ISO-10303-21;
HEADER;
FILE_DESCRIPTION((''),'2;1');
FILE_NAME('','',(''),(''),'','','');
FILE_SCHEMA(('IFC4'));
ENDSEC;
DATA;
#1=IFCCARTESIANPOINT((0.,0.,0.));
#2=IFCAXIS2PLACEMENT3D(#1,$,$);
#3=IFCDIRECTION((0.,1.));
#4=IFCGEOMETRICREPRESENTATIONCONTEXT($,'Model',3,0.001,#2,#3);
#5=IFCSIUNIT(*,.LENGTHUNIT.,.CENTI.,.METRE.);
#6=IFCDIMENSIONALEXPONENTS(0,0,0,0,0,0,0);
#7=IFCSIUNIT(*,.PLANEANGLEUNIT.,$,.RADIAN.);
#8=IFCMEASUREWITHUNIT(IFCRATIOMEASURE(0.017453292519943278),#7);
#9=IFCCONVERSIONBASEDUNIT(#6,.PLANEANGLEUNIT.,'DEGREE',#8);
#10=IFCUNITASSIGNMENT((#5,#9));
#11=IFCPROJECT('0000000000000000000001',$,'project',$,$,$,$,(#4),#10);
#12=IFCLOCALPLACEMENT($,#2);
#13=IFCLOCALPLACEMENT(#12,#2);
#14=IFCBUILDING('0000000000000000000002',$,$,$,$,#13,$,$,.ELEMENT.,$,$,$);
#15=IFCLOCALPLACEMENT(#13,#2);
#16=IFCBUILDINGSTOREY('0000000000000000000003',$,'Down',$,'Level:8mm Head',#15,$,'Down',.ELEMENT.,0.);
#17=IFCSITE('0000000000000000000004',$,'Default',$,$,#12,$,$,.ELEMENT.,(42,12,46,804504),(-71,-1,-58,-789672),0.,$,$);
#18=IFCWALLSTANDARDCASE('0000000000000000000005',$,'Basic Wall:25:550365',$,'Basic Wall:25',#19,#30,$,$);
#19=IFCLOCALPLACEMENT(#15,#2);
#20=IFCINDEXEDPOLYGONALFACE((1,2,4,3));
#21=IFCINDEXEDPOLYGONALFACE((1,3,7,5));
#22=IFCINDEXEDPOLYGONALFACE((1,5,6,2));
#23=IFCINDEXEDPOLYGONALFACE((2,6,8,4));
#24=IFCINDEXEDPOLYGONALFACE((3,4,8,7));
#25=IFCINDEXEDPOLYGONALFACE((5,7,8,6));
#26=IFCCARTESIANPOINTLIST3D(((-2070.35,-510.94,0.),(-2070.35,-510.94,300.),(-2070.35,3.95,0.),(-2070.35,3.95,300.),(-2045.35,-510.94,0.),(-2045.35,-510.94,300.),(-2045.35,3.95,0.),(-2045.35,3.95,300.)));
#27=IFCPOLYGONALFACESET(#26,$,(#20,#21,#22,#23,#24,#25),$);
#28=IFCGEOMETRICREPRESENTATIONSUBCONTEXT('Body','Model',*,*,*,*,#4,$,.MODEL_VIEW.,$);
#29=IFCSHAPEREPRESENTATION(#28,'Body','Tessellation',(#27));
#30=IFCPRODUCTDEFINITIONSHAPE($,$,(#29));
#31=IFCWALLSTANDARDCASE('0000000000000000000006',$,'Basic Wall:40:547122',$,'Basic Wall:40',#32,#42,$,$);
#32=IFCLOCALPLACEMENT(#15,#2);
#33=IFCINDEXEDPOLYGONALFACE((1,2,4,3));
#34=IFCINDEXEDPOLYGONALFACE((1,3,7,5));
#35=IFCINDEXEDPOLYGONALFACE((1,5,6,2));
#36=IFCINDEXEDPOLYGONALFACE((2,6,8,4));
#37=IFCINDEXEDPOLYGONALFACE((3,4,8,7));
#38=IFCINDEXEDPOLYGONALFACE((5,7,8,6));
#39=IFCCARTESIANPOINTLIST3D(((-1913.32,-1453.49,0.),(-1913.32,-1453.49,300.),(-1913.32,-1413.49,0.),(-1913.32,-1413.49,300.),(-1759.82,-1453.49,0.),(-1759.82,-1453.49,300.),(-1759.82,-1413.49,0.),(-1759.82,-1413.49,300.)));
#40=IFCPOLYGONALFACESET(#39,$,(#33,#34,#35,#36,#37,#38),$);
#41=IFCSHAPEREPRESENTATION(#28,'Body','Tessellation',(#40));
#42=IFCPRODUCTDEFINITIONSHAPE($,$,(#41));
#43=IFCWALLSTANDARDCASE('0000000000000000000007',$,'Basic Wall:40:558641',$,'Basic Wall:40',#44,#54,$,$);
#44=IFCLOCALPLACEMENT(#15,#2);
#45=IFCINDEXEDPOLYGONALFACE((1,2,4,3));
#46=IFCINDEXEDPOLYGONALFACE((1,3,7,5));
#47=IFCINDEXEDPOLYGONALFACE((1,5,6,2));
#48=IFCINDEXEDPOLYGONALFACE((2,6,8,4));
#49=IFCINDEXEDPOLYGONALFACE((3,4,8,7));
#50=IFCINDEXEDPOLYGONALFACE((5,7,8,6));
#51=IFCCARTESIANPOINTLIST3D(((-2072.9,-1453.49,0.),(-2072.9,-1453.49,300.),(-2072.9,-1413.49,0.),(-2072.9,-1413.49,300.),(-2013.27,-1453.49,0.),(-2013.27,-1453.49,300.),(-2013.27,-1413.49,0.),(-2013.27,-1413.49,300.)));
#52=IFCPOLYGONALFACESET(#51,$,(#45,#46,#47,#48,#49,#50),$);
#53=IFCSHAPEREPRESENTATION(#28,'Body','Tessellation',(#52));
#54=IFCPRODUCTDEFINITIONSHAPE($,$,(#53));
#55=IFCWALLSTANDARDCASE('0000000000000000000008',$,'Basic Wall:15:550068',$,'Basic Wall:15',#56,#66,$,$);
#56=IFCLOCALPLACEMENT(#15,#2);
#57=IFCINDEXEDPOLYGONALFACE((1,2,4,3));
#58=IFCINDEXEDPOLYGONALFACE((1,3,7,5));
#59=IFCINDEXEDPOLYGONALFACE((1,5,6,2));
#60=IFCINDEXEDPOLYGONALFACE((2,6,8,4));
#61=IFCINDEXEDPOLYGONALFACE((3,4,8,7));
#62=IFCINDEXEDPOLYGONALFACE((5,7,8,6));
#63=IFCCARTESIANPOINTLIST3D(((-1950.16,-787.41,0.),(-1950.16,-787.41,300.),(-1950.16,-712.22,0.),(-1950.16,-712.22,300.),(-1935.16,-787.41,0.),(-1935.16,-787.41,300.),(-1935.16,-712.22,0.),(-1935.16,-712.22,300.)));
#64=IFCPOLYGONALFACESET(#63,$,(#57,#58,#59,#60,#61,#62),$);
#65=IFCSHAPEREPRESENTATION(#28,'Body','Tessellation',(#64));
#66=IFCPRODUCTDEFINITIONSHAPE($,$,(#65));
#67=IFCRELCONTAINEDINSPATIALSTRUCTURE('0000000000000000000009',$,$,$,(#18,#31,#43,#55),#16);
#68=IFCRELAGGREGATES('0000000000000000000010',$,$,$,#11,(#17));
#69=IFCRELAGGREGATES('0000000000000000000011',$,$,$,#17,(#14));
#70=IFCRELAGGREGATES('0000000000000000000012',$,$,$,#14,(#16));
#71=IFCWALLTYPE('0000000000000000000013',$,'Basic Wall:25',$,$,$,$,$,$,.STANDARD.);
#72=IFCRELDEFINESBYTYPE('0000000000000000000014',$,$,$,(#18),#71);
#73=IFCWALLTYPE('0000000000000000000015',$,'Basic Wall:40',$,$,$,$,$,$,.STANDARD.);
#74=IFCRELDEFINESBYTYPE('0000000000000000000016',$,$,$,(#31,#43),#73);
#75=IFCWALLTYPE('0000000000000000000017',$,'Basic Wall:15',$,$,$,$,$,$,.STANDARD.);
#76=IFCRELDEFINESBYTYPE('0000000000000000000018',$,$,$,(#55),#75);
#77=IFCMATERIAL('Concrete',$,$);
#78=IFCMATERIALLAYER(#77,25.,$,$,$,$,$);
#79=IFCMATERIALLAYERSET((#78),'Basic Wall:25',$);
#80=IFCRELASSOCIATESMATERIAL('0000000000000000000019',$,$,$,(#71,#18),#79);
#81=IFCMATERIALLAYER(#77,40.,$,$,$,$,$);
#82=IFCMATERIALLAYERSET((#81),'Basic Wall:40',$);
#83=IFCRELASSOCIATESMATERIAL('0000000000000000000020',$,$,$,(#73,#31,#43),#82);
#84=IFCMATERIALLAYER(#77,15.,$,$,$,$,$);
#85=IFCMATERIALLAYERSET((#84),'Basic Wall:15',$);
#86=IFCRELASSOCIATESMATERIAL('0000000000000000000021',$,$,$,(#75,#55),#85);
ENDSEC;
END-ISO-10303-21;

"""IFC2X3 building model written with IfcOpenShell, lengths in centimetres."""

from ifc_helpers import new_model, entity, si_unit, converted_unit, direction, frame, frame_2d, origin, place, context, subcontext, project, spatial, rectangle, extrude, material, layer, layer_set, layer_usage, type_object, element, save


model = new_model("IFC2X3")

# Units and contexts
model_context = context("Model", 3, precision=0.001, world=origin(), true_north=direction((0.0, 1.0)))
body_context = subcontext(model_context, "Body", "Model", "MODEL_VIEW")
ifc_project = project(units=[si_unit("LENGTHUNIT", "METRE", prefix="CENTI"), converted_unit("PLANEANGLEUNIT", "DEGREE", entity("IfcRatioMeasure", 0.017453292519943278), si_unit("PLANEANGLEUNIT", "RADIAN"), dimensions=[0, 0, 0, 0, 0, 0, 0])], contexts=[model_context])

# Site, building, storey
site_placement = place(None, origin())
site = spatial("IfcSite", under=ifc_project, at=site_placement, Name="Default", CompositionType="ELEMENT", RefLatitude=(42, 12, 46, 804504), RefLongitude=(-71, -1, -58, -789672), RefElevation=0.0)
building_placement = place(site_placement, origin())
building = spatial("IfcBuilding", under=site, at=building_placement, CompositionType="ELEMENT")
storey_placement = place(building_placement, origin())
storey = spatial("IfcBuildingStorey", under=building, at=storey_placement, Name="Down", ObjectType="Level:8mm Head", LongName="Down", CompositionType="ELEMENT", Elevation=0.0)

# Walls
ifc_material = material(Name="Concrete")
ifc_layer_1 = layer(ifc_material, 25.0)
ifc_layer_set_1 = layer_set([ifc_layer_1], Name="Basic Wall:25")
wall_type_1 = type_object("IfcWallType", Name="Basic Wall:25", PredefinedType="STANDARD", material=ifc_layer_set_1)
ifc_layer_usage_1 = layer_usage(ifc_layer_set_1, "AXIS2", "NEGATIVE", 12.5)
wall_1_placement = place(storey_placement, frame((-2057.85, -510.94, 0.0), z_axis=(0.0, 0.0, 1.0), x_axis=(0.0, 1.0, 0.0)))
element("IfcWallStandardCase", 1, at=wall_1_placement, inside=storey, type_object=wall_type_1, material=ifc_layer_usage_1, Name="Basic Wall:25:550365", ObjectType="Basic Wall:25", context=body_context, shape_type="SweptSolid", body=[
    extrude(rectangle(XDim=514.89, YDim=25.0, at=frame_2d((257.44, 0.0), x_axis=(-1.0, 0.0))), origin(), (0.0, 0.0, 1.0), 300.0),
])
ifc_layer_2 = layer(ifc_material, 40.0)
ifc_layer_set_2 = layer_set([ifc_layer_2], Name="Basic Wall:40")
ifc_layer_usage_2 = layer_usage(ifc_layer_set_2, "AXIS2", "POSITIVE", -20.0)
wall_type_2 = type_object("IfcWallType", Name="Basic Wall:40", PredefinedType="STANDARD", material=ifc_layer_set_2)
wall_2_placement = place(storey_placement, frame((-1913.32, -1433.49, 0.0)))
element("IfcWallStandardCase", 2, at=wall_2_placement, inside=storey, type_object=wall_type_2, material=ifc_layer_usage_2, Name="Basic Wall:40:547122", ObjectType="Basic Wall:40", context=body_context, shape_type="SweptSolid", body=[
    extrude(rectangle(XDim=153.5, YDim=40.0, at=frame_2d((76.75, 0.0), x_axis=(-1.0, 0.0))), origin(), (0.0, 0.0, 1.0), 300.0),
])
ifc_layer_usage_3 = layer_usage(ifc_layer_set_2, "AXIS2", "POSITIVE", -20.0)
wall_3_placement = place(storey_placement, frame((-2072.9, -1433.49, 0.0)))
element("IfcWallStandardCase", 3, at=wall_3_placement, inside=storey, type_object=wall_type_2, material=ifc_layer_usage_3, Name="Basic Wall:40:558641", ObjectType="Basic Wall:40", context=body_context, shape_type="SweptSolid", body=[
    extrude(rectangle(XDim=59.63, YDim=40.0, at=frame_2d((29.81, 0.0), x_axis=(-1.0, 0.0))), origin(), (0.0, 0.0, 1.0), 300.0),
])
ifc_layer_3 = layer(ifc_material, 15.0)
ifc_layer_set_3 = layer_set([ifc_layer_3], Name="Basic Wall:15")
ifc_layer_usage_4 = layer_usage(ifc_layer_set_3, "AXIS2", "NEGATIVE", 7.5)
wall_type_3 = type_object("IfcWallType", Name="Basic Wall:15", PredefinedType="STANDARD", material=ifc_layer_set_3)
wall_4_placement = place(storey_placement, frame((-1942.66, -712.22, 0.0), z_axis=(0.0, 0.0, 1.0), x_axis=(0.0, -1.0, 0.0)))
element("IfcWallStandardCase", 4, at=wall_4_placement, inside=storey, type_object=wall_type_3, material=ifc_layer_usage_4, Name="Basic Wall:15:550068", ObjectType="Basic Wall:15", context=body_context, shape_type="SweptSolid", body=[
    extrude(rectangle(XDim=75.19, YDim=15.0, at=frame_2d((37.6, 0.0), x_axis=(-1.0, 0.0))), origin(), (0.0, 0.0, 1.0), 300.0),
])

save(model, "model.ifc")
